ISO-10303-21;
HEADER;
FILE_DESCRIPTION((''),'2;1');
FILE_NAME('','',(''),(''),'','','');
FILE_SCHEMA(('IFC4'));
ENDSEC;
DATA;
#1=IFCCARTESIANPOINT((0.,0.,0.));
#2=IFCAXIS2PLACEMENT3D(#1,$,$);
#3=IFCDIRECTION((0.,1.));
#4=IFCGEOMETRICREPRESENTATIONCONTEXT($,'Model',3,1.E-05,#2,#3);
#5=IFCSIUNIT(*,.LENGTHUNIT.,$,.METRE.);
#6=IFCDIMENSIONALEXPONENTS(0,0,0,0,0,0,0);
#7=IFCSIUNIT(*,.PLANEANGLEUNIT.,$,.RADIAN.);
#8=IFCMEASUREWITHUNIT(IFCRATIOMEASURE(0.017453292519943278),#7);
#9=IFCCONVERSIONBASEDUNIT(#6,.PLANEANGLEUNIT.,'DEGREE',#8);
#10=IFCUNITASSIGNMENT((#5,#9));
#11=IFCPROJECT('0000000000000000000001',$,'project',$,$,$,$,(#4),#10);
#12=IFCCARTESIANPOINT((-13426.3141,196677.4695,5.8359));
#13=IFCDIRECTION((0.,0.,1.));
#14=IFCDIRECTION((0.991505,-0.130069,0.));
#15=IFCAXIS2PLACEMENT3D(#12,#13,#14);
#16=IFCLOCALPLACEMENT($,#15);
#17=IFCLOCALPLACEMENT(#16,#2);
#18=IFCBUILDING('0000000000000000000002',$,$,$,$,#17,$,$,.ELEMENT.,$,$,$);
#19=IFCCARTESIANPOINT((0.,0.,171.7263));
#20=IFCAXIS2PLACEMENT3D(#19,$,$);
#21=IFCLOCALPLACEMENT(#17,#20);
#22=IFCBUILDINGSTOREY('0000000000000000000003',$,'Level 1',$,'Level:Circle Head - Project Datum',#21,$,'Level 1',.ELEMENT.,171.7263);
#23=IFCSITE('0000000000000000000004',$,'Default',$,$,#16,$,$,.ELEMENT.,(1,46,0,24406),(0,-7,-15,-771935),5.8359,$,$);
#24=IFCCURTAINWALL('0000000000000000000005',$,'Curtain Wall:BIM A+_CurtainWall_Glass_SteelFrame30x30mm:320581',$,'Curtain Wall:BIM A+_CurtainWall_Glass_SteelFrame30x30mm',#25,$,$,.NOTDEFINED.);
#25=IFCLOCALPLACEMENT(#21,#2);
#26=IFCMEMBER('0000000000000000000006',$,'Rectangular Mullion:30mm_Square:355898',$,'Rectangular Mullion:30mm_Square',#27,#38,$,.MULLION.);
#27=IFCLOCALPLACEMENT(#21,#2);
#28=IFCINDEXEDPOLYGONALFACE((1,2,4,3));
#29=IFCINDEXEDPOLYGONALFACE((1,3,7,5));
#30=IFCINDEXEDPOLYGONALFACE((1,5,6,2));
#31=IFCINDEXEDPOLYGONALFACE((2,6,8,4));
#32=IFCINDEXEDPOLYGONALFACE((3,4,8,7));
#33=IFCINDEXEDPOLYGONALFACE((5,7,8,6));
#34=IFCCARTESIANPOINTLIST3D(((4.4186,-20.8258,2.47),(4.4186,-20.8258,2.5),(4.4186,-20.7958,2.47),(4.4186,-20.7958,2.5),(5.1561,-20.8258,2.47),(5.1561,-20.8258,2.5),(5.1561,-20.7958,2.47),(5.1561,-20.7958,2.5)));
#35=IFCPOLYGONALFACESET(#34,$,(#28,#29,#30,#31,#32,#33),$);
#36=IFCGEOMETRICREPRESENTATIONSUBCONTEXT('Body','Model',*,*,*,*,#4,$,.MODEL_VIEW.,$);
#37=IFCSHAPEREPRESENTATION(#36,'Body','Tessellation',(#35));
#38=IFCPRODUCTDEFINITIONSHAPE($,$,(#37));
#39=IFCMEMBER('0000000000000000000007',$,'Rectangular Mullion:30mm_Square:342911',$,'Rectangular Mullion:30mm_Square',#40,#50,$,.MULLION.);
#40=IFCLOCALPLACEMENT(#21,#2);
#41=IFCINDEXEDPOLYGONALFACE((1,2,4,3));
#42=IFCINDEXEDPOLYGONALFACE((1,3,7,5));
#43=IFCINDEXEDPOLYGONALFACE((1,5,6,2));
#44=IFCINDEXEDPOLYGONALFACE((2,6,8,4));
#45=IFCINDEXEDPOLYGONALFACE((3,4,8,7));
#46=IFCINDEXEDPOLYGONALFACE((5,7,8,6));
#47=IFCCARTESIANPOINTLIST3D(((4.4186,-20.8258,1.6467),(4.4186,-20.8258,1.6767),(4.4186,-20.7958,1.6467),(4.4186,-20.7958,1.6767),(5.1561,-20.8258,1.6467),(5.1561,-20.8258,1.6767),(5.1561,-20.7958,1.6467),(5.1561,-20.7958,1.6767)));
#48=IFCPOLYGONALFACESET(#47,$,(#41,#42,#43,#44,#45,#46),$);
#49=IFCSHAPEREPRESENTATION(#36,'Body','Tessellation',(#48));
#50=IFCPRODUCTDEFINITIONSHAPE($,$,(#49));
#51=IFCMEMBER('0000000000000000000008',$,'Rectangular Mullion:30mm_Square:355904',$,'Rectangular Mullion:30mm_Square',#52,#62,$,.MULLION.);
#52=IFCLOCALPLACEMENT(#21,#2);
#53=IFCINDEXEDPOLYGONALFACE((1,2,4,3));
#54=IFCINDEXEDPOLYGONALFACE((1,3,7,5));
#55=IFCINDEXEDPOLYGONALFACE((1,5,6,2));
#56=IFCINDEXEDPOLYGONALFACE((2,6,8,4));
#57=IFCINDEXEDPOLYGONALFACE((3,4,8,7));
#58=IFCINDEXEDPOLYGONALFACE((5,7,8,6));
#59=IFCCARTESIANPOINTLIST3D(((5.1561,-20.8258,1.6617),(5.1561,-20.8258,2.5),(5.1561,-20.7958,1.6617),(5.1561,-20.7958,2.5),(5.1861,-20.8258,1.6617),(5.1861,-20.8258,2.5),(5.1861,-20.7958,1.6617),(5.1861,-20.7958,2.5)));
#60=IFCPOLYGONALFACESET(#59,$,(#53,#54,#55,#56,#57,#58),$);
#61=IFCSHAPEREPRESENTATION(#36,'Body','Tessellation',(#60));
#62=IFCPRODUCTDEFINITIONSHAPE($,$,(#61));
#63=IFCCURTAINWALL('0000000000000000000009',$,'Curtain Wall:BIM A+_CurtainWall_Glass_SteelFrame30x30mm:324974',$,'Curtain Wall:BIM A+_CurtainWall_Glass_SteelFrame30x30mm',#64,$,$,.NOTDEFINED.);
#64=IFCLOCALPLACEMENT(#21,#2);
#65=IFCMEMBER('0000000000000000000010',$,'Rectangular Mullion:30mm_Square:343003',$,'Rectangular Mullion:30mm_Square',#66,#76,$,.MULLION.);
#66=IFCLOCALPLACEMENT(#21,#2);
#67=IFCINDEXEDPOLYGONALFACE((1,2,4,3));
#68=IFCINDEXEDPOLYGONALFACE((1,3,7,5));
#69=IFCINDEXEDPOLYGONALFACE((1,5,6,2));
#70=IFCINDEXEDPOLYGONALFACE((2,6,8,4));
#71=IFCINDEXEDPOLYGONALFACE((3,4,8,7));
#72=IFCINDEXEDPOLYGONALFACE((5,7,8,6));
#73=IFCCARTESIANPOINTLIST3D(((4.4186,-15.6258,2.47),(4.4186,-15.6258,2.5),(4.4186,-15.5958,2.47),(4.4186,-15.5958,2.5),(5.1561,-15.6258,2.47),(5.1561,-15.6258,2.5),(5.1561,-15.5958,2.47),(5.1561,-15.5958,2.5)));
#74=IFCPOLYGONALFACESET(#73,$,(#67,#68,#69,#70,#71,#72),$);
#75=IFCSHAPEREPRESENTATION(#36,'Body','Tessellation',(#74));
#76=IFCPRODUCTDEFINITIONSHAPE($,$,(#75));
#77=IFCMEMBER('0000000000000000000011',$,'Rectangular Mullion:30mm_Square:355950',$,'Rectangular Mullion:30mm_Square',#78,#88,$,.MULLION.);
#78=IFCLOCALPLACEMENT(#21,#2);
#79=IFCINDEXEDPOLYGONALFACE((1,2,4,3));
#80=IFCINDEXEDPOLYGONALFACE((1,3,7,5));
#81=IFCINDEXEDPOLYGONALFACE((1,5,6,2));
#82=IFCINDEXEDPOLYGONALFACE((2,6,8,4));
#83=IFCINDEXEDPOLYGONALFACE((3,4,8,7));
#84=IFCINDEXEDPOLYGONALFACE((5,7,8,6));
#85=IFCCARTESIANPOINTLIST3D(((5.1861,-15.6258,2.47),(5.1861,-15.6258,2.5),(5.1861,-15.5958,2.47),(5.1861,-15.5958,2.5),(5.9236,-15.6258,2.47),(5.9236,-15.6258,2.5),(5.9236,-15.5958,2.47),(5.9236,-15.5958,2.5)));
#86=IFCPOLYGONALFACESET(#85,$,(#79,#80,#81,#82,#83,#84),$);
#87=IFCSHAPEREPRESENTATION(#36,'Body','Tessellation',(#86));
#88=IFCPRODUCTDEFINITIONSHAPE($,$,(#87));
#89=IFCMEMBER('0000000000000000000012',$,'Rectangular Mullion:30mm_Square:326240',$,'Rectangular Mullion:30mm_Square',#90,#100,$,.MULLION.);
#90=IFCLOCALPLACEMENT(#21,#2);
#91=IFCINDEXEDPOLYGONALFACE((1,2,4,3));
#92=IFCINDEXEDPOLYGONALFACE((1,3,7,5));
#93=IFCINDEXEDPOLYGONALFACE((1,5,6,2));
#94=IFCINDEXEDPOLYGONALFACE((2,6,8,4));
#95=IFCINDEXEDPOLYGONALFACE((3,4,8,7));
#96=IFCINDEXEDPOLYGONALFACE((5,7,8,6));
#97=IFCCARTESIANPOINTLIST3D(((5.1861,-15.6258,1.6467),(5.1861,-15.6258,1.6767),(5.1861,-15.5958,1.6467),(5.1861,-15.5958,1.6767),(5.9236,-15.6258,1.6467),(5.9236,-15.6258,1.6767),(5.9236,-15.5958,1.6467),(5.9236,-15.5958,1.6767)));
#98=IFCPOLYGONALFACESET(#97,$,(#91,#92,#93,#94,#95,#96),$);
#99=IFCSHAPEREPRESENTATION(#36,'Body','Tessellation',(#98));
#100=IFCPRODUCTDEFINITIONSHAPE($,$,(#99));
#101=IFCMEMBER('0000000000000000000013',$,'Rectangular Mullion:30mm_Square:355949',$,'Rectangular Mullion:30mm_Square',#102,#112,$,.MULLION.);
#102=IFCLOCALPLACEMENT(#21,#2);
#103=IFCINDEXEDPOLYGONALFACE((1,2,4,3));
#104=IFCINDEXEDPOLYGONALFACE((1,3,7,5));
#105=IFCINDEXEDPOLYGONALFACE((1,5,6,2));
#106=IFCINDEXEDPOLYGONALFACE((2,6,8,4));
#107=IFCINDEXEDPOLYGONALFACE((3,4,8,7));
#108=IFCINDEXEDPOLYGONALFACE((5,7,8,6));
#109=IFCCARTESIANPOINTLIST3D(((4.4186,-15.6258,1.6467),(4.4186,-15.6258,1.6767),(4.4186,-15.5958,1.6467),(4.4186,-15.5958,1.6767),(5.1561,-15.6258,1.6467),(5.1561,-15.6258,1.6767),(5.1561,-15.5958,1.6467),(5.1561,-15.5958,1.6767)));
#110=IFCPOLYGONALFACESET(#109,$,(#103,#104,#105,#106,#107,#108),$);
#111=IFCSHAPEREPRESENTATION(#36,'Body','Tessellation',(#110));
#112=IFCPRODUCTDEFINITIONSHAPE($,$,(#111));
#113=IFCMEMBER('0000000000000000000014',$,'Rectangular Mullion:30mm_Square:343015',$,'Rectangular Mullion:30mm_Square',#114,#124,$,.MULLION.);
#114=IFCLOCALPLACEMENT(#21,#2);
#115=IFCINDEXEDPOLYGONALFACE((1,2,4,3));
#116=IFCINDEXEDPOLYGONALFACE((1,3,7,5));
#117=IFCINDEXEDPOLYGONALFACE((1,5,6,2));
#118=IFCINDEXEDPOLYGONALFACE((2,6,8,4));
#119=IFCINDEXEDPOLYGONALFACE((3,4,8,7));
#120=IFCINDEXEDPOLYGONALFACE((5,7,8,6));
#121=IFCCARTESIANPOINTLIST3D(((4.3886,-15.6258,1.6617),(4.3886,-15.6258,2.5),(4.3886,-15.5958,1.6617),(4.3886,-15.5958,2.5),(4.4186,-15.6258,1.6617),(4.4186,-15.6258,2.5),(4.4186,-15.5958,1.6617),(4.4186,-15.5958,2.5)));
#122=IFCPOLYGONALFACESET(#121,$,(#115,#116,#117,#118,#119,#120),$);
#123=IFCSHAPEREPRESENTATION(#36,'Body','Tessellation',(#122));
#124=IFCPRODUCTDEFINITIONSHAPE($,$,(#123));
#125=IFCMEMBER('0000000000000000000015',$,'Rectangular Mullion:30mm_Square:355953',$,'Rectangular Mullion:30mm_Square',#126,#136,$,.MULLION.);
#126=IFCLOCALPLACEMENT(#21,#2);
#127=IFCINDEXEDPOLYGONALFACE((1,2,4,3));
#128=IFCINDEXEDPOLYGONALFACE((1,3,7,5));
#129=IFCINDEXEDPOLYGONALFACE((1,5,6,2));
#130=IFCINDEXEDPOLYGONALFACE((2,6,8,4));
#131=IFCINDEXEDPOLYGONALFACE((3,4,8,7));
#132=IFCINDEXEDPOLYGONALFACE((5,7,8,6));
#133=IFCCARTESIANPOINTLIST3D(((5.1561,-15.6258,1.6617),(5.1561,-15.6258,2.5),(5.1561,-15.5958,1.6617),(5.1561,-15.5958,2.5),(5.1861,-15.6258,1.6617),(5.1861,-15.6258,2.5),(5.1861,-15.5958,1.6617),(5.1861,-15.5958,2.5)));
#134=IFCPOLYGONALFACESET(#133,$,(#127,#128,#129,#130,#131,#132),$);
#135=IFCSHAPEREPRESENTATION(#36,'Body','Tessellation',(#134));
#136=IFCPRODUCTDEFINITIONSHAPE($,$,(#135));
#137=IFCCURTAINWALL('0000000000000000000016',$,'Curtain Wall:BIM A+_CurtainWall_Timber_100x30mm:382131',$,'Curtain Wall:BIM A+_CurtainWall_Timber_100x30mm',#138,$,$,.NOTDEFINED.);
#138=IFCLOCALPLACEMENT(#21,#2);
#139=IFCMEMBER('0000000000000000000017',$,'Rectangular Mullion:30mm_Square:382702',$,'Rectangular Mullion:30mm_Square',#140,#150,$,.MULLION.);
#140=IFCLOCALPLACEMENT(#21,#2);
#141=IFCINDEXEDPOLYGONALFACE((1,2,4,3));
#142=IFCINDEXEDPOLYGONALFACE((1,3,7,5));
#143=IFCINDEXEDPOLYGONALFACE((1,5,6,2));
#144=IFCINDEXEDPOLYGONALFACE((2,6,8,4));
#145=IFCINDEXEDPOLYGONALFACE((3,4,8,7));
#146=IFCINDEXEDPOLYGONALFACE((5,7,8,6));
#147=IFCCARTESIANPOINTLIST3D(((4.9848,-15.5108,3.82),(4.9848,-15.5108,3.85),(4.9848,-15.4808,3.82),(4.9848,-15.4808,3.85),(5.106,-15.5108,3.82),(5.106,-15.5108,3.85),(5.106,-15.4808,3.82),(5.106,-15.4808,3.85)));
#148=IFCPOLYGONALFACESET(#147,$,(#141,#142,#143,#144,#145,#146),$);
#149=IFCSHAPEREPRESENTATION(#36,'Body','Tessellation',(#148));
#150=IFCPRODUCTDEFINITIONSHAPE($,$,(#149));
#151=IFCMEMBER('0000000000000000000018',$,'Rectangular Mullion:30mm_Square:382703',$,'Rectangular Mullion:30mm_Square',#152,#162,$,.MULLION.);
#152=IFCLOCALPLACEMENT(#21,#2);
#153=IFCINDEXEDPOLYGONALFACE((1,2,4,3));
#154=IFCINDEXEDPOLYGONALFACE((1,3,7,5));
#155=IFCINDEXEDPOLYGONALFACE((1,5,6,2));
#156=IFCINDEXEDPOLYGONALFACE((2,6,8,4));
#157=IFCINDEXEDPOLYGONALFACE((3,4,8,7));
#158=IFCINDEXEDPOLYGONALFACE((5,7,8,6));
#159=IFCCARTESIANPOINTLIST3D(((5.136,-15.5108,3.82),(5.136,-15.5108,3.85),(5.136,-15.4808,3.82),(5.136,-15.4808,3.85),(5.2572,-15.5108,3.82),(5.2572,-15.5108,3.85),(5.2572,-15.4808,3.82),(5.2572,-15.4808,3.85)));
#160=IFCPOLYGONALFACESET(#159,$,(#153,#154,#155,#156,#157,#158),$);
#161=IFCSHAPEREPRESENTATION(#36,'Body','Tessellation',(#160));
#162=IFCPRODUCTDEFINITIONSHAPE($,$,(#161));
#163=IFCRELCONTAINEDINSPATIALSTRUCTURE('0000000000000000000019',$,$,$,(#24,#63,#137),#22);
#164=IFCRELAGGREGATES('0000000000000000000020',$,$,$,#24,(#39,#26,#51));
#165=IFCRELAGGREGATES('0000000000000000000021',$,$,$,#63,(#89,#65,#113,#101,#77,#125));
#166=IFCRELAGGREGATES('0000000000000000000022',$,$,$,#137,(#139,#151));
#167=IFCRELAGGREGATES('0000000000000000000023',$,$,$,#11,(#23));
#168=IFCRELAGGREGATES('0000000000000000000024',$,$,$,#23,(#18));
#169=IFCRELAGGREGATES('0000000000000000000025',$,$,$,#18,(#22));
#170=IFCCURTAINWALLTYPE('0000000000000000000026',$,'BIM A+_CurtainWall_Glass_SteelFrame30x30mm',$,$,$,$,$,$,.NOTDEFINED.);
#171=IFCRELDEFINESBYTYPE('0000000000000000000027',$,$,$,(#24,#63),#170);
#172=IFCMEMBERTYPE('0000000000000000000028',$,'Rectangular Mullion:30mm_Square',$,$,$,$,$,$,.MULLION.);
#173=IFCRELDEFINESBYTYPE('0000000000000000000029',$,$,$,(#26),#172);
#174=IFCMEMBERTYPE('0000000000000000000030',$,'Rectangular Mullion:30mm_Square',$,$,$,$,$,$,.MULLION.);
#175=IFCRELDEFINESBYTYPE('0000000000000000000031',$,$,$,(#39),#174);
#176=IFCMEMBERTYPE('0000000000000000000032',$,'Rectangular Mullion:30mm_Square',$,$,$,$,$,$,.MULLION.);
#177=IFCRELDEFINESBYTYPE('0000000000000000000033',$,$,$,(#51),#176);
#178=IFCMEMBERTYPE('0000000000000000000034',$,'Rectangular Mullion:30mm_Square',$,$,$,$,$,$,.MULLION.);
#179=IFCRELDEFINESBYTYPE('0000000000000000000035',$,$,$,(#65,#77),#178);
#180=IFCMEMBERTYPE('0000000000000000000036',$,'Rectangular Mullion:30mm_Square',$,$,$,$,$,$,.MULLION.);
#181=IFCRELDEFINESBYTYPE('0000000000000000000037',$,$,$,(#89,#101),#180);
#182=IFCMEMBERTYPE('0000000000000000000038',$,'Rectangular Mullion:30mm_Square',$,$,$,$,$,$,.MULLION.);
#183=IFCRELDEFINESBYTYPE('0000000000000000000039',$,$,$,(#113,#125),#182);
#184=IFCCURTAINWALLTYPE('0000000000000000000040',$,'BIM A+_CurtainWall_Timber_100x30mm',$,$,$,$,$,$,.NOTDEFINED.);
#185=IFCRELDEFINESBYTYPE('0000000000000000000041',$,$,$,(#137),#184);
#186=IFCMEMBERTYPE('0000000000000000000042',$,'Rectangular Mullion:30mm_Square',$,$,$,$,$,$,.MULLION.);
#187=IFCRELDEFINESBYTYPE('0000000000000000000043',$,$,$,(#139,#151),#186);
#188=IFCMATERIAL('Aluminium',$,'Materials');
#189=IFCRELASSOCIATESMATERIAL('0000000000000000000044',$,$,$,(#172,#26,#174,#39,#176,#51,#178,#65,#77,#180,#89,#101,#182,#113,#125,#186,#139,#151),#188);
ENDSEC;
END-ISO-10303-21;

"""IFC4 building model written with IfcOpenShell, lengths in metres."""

from ifc_helpers import new_model, entity, si_unit, converted_unit, direction, frame, origin, place, context, subcontext, project, spatial, indexed_curve, outline, extrude, source, transform, mapped, material, type_object, type_shapes, element, aggregate, save


model = new_model("IFC4")

# Units and contexts
model_context = context("Model", 3, precision=1e-05, world=origin(), true_north=direction((0.0, 1.0)))
body_context = subcontext(model_context, "Body", "Model", "MODEL_VIEW")
ifc_project = project(units=[si_unit("LENGTHUNIT", "METRE"), converted_unit("PLANEANGLEUNIT", "DEGREE", entity("IfcRatioMeasure", 0.017453292519943278), si_unit("PLANEANGLEUNIT", "RADIAN"), dimensions=[0, 0, 0, 0, 0, 0, 0])], contexts=[model_context])

# Site, building, storey
site_placement = place(None, frame((-13426.3141, 196677.4695, 5.8359), z_axis=(0.0, 0.0, 1.0), x_axis=(0.991505, -0.130069, 0.0)))
site = spatial("IfcSite", under=ifc_project, at=site_placement, Name="Default", CompositionType="ELEMENT", RefLatitude=(1, 46, 0, 24406), RefLongitude=(0, -7, -15, -771935), RefElevation=5.8359)
building_placement = place(site_placement, origin())
building = spatial("IfcBuilding", under=site, at=building_placement, CompositionType="ELEMENT")
storey_placement = place(building_placement, frame((0.0, 0.0, 171.7263)))
storey = spatial("IfcBuildingStorey", under=building, at=storey_placement, Name="Level 1", ObjectType="Level:Circle Head - Project Datum", LongName="Level 1", CompositionType="ELEMENT", Elevation=171.7263)

# Curtain walls, members
curtain_wall_type_1 = type_object("IfcCurtainWallType", Name="BIM A+_CurtainWall_Glass_SteelFrame30x30mm", PredefinedType="NOTDEFINED")
curtain_wall_1_placement = place(storey_placement, frame((0.0, 0.0, -171.7263)))
curtain_wall_1 = element("IfcCurtainWall", 1, at=curtain_wall_1_placement, inside=storey, type_object=curtain_wall_type_1, Name="Curtain Wall:BIM A+_CurtainWall_Glass_SteelFrame30x30mm:320581", ObjectType="Curtain Wall:BIM A+_CurtainWall_Glass_SteelFrame30x30mm", PredefinedType="NOTDEFINED")
ifc_material_1 = material(Name="Aluminium", Category="Materials")
member_type_1 = type_object("IfcMemberType", Name="Rectangular Mullion:30mm_Square", PredefinedType="MULLION", material=ifc_material_1)
shared_shape_1 = source(origin(), body_context, "Body", "SweptSolid", [
    extrude(outline(indexed_curve([(-0.015, -0.015), (0.015, -0.015), (0.015, 0.015), (-0.015, 0.015), (-0.015, -0.015)], self_intersect=False)), frame((-0.015, 0.0, -0.7375), z_axis=(0.0, 0.0, 1.0), x_axis=(0.0, -1.0, 0.0)), (0.0, 0.0, 1.0), 0.7375),
])
type_shapes(member_type_1, [shared_shape_1])
member_1_placement = place(curtain_wall_1_placement, frame((5.1561, -20.8108, 174.2263), z_axis=(1.0, 0.0, 0.0), x_axis=(0.0, 0.0, 1.0)))
member_1 = element("IfcMember", 2, at=member_1_placement, type_object=member_type_1, material=ifc_material_1, Name="Rectangular Mullion:30mm_Square:355898", ObjectType="Rectangular Mullion:30mm_Square", PredefinedType="MULLION", context=body_context, shape_type="MappedRepresentation", body=[
    mapped(shared_shape_1, transform((0.0, 0.0, 0.0), scale=1.0)),
])
member_type_2 = type_object("IfcMemberType", Name="Rectangular Mullion:30mm_Square", PredefinedType="MULLION", material=ifc_material_1)
shared_shape_2 = source(origin(), body_context, "Body", "SweptSolid", [
    extrude(outline(indexed_curve([(-0.015, -0.015), (0.015, -0.015), (0.015, 0.015), (-0.015, 0.015), (-0.015, -0.015)], self_intersect=False)), frame((0.0, 0.0, -0.7375), z_axis=(0.0, 0.0, 1.0), x_axis=(0.0, -1.0, 0.0)), (0.0, 0.0, 1.0), 0.7375),
])
type_shapes(member_type_2, [shared_shape_2])
member_2_placement = place(curtain_wall_1_placement, frame((5.1561, -20.8108, 173.3879), z_axis=(1.0, 0.0, 0.0), x_axis=(0.0, 0.0, 1.0)))
member_2 = element("IfcMember", 3, at=member_2_placement, type_object=member_type_2, material=ifc_material_1, Name="Rectangular Mullion:30mm_Square:342911", ObjectType="Rectangular Mullion:30mm_Square", PredefinedType="MULLION", context=body_context, shape_type="MappedRepresentation", body=[
    mapped(shared_shape_2, transform((0.0, 0.0, 0.0), scale=1.0)),
])
member_type_3 = type_object("IfcMemberType", Name="Rectangular Mullion:30mm_Square", PredefinedType="MULLION", material=ifc_material_1)
shared_shape_3 = source(origin(), body_context, "Body", "SweptSolid", [
    extrude(outline(indexed_curve([(-0.015, -0.015), (0.015, -0.015), (0.015, 0.015), (-0.015, 0.015), (-0.015, -0.015)], self_intersect=False)), frame((0.0, 0.0, -0.8383), z_axis=(0.0, 0.0, 1.0), x_axis=(0.0, -1.0, 0.0)), (0.0, 0.0, 1.0), 0.8383),
])
type_shapes(member_type_3, [shared_shape_3])
member_3_placement = place(curtain_wall_1_placement, frame((5.1711, -20.8108, 173.3879), z_axis=(0.0, 0.0, -1.0), x_axis=(1.0, 0.0, 0.0)))
member_3 = element("IfcMember", 4, at=member_3_placement, type_object=member_type_3, material=ifc_material_1, Name="Rectangular Mullion:30mm_Square:355904", ObjectType="Rectangular Mullion:30mm_Square", PredefinedType="MULLION", context=body_context, shape_type="MappedRepresentation", body=[
    mapped(shared_shape_3, transform((0.0, 0.0, 0.0), scale=1.0)),
])
curtain_wall_2_placement = place(storey_placement, frame((0.0, 0.0, -171.7263)))
curtain_wall_2 = element("IfcCurtainWall", 5, at=curtain_wall_2_placement, inside=storey, type_object=curtain_wall_type_1, Name="Curtain Wall:BIM A+_CurtainWall_Glass_SteelFrame30x30mm:324974", ObjectType="Curtain Wall:BIM A+_CurtainWall_Glass_SteelFrame30x30mm", PredefinedType="NOTDEFINED")
member_type_4 = type_object("IfcMemberType", Name="Rectangular Mullion:30mm_Square", PredefinedType="MULLION", material=ifc_material_1)
shared_shape_4 = source(origin(), body_context, "Body", "SweptSolid", [
    extrude(outline(indexed_curve([(-0.015, -0.015), (0.015, -0.015), (0.015, 0.015), (-0.015, 0.015), (-0.015, -0.015)], self_intersect=False)), frame((-0.015, 0.0, -0.7375), z_axis=(0.0, 0.0, 1.0), x_axis=(0.0, -1.0, 0.0)), (0.0, 0.0, 1.0), 0.7375),
])
type_shapes(member_type_4, [shared_shape_4])
member_4_placement = place(curtain_wall_2_placement, frame((4.4186, -15.6108, 174.2263), z_axis=(-1.0, 0.0, 0.0), x_axis=(0.0, 0.0, 1.0)))
member_4 = element("IfcMember", 6, at=member_4_placement, type_object=member_type_4, material=ifc_material_1, Name="Rectangular Mullion:30mm_Square:343003", ObjectType="Rectangular Mullion:30mm_Square", PredefinedType="MULLION", context=body_context, shape_type="MappedRepresentation", body=[
    mapped(shared_shape_4, transform((0.0, 0.0, 0.0), scale=1.0)),
])
member_5_placement = place(curtain_wall_2_placement, frame((5.1861, -15.6108, 174.2263), z_axis=(-1.0, 0.0, 0.0), x_axis=(0.0, 0.0, 1.0)))
member_5 = element("IfcMember", 7, at=member_5_placement, type_object=member_type_4, material=ifc_material_1, Name="Rectangular Mullion:30mm_Square:355950", ObjectType="Rectangular Mullion:30mm_Square", PredefinedType="MULLION", context=body_context, shape_type="MappedRepresentation", body=[
    mapped(shared_shape_4, transform((0.0, 0.0, 0.0), scale=1.0)),
])
member_type_5 = type_object("IfcMemberType", Name="Rectangular Mullion:30mm_Square", PredefinedType="MULLION", material=ifc_material_1)
shared_shape_5 = source(origin(), body_context, "Body", "SweptSolid", [
    extrude(outline(indexed_curve([(-0.015, -0.015), (0.015, -0.015), (0.015, 0.015), (-0.015, 0.015), (-0.015, -0.015)], self_intersect=False)), frame((0.0, 0.0, -0.7375), z_axis=(0.0, 0.0, 1.0), x_axis=(0.0, -1.0, 0.0)), (0.0, 0.0, 1.0), 0.7375),
])
type_shapes(member_type_5, [shared_shape_5])
member_6_placement = place(curtain_wall_2_placement, frame((5.1861, -15.6108, 173.3879), z_axis=(-1.0, 0.0, 0.0), x_axis=(0.0, 0.0, 1.0)))
member_6 = element("IfcMember", 8, at=member_6_placement, type_object=member_type_5, material=ifc_material_1, Name="Rectangular Mullion:30mm_Square:326240", ObjectType="Rectangular Mullion:30mm_Square", PredefinedType="MULLION", context=body_context, shape_type="MappedRepresentation", body=[
    mapped(shared_shape_5, transform((0.0, 0.0, 0.0), scale=1.0)),
])
member_7_placement = place(curtain_wall_2_placement, frame((4.4186, -15.6108, 173.3879), z_axis=(-1.0, 0.0, 0.0), x_axis=(0.0, 0.0, 1.0)))
member_7 = element("IfcMember", 9, at=member_7_placement, type_object=member_type_5, material=ifc_material_1, Name="Rectangular Mullion:30mm_Square:355949", ObjectType="Rectangular Mullion:30mm_Square", PredefinedType="MULLION", context=body_context, shape_type="MappedRepresentation", body=[
    mapped(shared_shape_5, transform((0.0, 0.0, 0.0), scale=1.0)),
])
member_type_6 = type_object("IfcMemberType", Name="Rectangular Mullion:30mm_Square", PredefinedType="MULLION", material=ifc_material_1)
shared_shape_6 = source(origin(), body_context, "Body", "SweptSolid", [
    extrude(outline(indexed_curve([(-0.015, -0.015), (0.015, -0.015), (0.015, 0.015), (-0.015, 0.015), (-0.015, -0.015)], self_intersect=False)), frame((0.0, 0.0, -0.8383), z_axis=(0.0, 0.0, 1.0), x_axis=(0.0, -1.0, 0.0)), (0.0, 0.0, 1.0), 0.8383),
])
type_shapes(member_type_6, [shared_shape_6])
member_8_placement = place(curtain_wall_2_placement, frame((4.4036, -15.6108, 173.3879), z_axis=(0.0, 0.0, -1.0), x_axis=(-1.0, 0.0, 0.0)))
member_8 = element("IfcMember", 10, at=member_8_placement, type_object=member_type_6, material=ifc_material_1, Name="Rectangular Mullion:30mm_Square:343015", ObjectType="Rectangular Mullion:30mm_Square", PredefinedType="MULLION", context=body_context, shape_type="MappedRepresentation", body=[
    mapped(shared_shape_6, transform((0.0, 0.0, 0.0), scale=1.0)),
])
member_9_placement = place(curtain_wall_2_placement, frame((5.1711, -15.6108, 173.3879), z_axis=(0.0, 0.0, -1.0), x_axis=(-1.0, 0.0, 0.0)))
member_9 = element("IfcMember", 11, at=member_9_placement, type_object=member_type_6, material=ifc_material_1, Name="Rectangular Mullion:30mm_Square:355953", ObjectType="Rectangular Mullion:30mm_Square", PredefinedType="MULLION", context=body_context, shape_type="MappedRepresentation", body=[
    mapped(shared_shape_6, transform((0.0, 0.0, 0.0), scale=1.0)),
])
curtain_wall_type_2 = type_object("IfcCurtainWallType", Name="BIM A+_CurtainWall_Timber_100x30mm", PredefinedType="NOTDEFINED")
curtain_wall_3_placement = place(storey_placement, frame((0.0, 0.0, -171.7263)))
curtain_wall_3 = element("IfcCurtainWall", 12, at=curtain_wall_3_placement, inside=storey, type_object=curtain_wall_type_2, Name="Curtain Wall:BIM A+_CurtainWall_Timber_100x30mm:382131", ObjectType="Curtain Wall:BIM A+_CurtainWall_Timber_100x30mm", PredefinedType="NOTDEFINED")
member_type_7 = type_object("IfcMemberType", Name="Rectangular Mullion:30mm_Square", PredefinedType="MULLION", material=ifc_material_1)
shared_shape_7 = source(origin(), body_context, "Body", "SweptSolid", [
    extrude(outline(indexed_curve([(-0.015, -0.015), (0.015, -0.015), (0.015, 0.015), (-0.015, 0.015), (-0.015, -0.015)], self_intersect=False)), frame((-0.015, 0.0, -0.1212), z_axis=(0.0, 0.0, 1.0), x_axis=(0.0, -1.0, 0.0)), (0.0, 0.0, 1.0), 0.1212),
])
type_shapes(member_type_7, [shared_shape_7])
member_10_placement = place(curtain_wall_3_placement, frame((5.106, -15.4958, 175.5763), z_axis=(1.0, 0.0, 0.0), x_axis=(0.0, 0.0, 1.0)))
member_10 = element("IfcMember", 13, at=member_10_placement, type_object=member_type_7, material=ifc_material_1, Name="Rectangular Mullion:30mm_Square:382702", ObjectType="Rectangular Mullion:30mm_Square", PredefinedType="MULLION", context=body_context, shape_type="MappedRepresentation", body=[
    mapped(shared_shape_7, transform((0.0, 0.0, 0.0), scale=1.0)),
])
member_11_placement = place(curtain_wall_3_placement, frame((5.2572, -15.4958, 175.5763), z_axis=(1.0, 0.0, 0.0), x_axis=(0.0, 0.0, 1.0)))
member_11 = element("IfcMember", 14, at=member_11_placement, type_object=member_type_7, material=ifc_material_1, Name="Rectangular Mullion:30mm_Square:382703", ObjectType="Rectangular Mullion:30mm_Square", PredefinedType="MULLION", context=body_context, shape_type="MappedRepresentation", body=[
    mapped(shared_shape_7, transform((0.0, 0.0, 0.0), scale=1.0)),
])

aggregate(curtain_wall_1, [member_2, member_1, member_3])
aggregate(curtain_wall_2, [member_6, member_4, member_8, member_7, member_5, member_9])
aggregate(curtain_wall_3, [member_10, member_11])

save(model, "model.ifc")
